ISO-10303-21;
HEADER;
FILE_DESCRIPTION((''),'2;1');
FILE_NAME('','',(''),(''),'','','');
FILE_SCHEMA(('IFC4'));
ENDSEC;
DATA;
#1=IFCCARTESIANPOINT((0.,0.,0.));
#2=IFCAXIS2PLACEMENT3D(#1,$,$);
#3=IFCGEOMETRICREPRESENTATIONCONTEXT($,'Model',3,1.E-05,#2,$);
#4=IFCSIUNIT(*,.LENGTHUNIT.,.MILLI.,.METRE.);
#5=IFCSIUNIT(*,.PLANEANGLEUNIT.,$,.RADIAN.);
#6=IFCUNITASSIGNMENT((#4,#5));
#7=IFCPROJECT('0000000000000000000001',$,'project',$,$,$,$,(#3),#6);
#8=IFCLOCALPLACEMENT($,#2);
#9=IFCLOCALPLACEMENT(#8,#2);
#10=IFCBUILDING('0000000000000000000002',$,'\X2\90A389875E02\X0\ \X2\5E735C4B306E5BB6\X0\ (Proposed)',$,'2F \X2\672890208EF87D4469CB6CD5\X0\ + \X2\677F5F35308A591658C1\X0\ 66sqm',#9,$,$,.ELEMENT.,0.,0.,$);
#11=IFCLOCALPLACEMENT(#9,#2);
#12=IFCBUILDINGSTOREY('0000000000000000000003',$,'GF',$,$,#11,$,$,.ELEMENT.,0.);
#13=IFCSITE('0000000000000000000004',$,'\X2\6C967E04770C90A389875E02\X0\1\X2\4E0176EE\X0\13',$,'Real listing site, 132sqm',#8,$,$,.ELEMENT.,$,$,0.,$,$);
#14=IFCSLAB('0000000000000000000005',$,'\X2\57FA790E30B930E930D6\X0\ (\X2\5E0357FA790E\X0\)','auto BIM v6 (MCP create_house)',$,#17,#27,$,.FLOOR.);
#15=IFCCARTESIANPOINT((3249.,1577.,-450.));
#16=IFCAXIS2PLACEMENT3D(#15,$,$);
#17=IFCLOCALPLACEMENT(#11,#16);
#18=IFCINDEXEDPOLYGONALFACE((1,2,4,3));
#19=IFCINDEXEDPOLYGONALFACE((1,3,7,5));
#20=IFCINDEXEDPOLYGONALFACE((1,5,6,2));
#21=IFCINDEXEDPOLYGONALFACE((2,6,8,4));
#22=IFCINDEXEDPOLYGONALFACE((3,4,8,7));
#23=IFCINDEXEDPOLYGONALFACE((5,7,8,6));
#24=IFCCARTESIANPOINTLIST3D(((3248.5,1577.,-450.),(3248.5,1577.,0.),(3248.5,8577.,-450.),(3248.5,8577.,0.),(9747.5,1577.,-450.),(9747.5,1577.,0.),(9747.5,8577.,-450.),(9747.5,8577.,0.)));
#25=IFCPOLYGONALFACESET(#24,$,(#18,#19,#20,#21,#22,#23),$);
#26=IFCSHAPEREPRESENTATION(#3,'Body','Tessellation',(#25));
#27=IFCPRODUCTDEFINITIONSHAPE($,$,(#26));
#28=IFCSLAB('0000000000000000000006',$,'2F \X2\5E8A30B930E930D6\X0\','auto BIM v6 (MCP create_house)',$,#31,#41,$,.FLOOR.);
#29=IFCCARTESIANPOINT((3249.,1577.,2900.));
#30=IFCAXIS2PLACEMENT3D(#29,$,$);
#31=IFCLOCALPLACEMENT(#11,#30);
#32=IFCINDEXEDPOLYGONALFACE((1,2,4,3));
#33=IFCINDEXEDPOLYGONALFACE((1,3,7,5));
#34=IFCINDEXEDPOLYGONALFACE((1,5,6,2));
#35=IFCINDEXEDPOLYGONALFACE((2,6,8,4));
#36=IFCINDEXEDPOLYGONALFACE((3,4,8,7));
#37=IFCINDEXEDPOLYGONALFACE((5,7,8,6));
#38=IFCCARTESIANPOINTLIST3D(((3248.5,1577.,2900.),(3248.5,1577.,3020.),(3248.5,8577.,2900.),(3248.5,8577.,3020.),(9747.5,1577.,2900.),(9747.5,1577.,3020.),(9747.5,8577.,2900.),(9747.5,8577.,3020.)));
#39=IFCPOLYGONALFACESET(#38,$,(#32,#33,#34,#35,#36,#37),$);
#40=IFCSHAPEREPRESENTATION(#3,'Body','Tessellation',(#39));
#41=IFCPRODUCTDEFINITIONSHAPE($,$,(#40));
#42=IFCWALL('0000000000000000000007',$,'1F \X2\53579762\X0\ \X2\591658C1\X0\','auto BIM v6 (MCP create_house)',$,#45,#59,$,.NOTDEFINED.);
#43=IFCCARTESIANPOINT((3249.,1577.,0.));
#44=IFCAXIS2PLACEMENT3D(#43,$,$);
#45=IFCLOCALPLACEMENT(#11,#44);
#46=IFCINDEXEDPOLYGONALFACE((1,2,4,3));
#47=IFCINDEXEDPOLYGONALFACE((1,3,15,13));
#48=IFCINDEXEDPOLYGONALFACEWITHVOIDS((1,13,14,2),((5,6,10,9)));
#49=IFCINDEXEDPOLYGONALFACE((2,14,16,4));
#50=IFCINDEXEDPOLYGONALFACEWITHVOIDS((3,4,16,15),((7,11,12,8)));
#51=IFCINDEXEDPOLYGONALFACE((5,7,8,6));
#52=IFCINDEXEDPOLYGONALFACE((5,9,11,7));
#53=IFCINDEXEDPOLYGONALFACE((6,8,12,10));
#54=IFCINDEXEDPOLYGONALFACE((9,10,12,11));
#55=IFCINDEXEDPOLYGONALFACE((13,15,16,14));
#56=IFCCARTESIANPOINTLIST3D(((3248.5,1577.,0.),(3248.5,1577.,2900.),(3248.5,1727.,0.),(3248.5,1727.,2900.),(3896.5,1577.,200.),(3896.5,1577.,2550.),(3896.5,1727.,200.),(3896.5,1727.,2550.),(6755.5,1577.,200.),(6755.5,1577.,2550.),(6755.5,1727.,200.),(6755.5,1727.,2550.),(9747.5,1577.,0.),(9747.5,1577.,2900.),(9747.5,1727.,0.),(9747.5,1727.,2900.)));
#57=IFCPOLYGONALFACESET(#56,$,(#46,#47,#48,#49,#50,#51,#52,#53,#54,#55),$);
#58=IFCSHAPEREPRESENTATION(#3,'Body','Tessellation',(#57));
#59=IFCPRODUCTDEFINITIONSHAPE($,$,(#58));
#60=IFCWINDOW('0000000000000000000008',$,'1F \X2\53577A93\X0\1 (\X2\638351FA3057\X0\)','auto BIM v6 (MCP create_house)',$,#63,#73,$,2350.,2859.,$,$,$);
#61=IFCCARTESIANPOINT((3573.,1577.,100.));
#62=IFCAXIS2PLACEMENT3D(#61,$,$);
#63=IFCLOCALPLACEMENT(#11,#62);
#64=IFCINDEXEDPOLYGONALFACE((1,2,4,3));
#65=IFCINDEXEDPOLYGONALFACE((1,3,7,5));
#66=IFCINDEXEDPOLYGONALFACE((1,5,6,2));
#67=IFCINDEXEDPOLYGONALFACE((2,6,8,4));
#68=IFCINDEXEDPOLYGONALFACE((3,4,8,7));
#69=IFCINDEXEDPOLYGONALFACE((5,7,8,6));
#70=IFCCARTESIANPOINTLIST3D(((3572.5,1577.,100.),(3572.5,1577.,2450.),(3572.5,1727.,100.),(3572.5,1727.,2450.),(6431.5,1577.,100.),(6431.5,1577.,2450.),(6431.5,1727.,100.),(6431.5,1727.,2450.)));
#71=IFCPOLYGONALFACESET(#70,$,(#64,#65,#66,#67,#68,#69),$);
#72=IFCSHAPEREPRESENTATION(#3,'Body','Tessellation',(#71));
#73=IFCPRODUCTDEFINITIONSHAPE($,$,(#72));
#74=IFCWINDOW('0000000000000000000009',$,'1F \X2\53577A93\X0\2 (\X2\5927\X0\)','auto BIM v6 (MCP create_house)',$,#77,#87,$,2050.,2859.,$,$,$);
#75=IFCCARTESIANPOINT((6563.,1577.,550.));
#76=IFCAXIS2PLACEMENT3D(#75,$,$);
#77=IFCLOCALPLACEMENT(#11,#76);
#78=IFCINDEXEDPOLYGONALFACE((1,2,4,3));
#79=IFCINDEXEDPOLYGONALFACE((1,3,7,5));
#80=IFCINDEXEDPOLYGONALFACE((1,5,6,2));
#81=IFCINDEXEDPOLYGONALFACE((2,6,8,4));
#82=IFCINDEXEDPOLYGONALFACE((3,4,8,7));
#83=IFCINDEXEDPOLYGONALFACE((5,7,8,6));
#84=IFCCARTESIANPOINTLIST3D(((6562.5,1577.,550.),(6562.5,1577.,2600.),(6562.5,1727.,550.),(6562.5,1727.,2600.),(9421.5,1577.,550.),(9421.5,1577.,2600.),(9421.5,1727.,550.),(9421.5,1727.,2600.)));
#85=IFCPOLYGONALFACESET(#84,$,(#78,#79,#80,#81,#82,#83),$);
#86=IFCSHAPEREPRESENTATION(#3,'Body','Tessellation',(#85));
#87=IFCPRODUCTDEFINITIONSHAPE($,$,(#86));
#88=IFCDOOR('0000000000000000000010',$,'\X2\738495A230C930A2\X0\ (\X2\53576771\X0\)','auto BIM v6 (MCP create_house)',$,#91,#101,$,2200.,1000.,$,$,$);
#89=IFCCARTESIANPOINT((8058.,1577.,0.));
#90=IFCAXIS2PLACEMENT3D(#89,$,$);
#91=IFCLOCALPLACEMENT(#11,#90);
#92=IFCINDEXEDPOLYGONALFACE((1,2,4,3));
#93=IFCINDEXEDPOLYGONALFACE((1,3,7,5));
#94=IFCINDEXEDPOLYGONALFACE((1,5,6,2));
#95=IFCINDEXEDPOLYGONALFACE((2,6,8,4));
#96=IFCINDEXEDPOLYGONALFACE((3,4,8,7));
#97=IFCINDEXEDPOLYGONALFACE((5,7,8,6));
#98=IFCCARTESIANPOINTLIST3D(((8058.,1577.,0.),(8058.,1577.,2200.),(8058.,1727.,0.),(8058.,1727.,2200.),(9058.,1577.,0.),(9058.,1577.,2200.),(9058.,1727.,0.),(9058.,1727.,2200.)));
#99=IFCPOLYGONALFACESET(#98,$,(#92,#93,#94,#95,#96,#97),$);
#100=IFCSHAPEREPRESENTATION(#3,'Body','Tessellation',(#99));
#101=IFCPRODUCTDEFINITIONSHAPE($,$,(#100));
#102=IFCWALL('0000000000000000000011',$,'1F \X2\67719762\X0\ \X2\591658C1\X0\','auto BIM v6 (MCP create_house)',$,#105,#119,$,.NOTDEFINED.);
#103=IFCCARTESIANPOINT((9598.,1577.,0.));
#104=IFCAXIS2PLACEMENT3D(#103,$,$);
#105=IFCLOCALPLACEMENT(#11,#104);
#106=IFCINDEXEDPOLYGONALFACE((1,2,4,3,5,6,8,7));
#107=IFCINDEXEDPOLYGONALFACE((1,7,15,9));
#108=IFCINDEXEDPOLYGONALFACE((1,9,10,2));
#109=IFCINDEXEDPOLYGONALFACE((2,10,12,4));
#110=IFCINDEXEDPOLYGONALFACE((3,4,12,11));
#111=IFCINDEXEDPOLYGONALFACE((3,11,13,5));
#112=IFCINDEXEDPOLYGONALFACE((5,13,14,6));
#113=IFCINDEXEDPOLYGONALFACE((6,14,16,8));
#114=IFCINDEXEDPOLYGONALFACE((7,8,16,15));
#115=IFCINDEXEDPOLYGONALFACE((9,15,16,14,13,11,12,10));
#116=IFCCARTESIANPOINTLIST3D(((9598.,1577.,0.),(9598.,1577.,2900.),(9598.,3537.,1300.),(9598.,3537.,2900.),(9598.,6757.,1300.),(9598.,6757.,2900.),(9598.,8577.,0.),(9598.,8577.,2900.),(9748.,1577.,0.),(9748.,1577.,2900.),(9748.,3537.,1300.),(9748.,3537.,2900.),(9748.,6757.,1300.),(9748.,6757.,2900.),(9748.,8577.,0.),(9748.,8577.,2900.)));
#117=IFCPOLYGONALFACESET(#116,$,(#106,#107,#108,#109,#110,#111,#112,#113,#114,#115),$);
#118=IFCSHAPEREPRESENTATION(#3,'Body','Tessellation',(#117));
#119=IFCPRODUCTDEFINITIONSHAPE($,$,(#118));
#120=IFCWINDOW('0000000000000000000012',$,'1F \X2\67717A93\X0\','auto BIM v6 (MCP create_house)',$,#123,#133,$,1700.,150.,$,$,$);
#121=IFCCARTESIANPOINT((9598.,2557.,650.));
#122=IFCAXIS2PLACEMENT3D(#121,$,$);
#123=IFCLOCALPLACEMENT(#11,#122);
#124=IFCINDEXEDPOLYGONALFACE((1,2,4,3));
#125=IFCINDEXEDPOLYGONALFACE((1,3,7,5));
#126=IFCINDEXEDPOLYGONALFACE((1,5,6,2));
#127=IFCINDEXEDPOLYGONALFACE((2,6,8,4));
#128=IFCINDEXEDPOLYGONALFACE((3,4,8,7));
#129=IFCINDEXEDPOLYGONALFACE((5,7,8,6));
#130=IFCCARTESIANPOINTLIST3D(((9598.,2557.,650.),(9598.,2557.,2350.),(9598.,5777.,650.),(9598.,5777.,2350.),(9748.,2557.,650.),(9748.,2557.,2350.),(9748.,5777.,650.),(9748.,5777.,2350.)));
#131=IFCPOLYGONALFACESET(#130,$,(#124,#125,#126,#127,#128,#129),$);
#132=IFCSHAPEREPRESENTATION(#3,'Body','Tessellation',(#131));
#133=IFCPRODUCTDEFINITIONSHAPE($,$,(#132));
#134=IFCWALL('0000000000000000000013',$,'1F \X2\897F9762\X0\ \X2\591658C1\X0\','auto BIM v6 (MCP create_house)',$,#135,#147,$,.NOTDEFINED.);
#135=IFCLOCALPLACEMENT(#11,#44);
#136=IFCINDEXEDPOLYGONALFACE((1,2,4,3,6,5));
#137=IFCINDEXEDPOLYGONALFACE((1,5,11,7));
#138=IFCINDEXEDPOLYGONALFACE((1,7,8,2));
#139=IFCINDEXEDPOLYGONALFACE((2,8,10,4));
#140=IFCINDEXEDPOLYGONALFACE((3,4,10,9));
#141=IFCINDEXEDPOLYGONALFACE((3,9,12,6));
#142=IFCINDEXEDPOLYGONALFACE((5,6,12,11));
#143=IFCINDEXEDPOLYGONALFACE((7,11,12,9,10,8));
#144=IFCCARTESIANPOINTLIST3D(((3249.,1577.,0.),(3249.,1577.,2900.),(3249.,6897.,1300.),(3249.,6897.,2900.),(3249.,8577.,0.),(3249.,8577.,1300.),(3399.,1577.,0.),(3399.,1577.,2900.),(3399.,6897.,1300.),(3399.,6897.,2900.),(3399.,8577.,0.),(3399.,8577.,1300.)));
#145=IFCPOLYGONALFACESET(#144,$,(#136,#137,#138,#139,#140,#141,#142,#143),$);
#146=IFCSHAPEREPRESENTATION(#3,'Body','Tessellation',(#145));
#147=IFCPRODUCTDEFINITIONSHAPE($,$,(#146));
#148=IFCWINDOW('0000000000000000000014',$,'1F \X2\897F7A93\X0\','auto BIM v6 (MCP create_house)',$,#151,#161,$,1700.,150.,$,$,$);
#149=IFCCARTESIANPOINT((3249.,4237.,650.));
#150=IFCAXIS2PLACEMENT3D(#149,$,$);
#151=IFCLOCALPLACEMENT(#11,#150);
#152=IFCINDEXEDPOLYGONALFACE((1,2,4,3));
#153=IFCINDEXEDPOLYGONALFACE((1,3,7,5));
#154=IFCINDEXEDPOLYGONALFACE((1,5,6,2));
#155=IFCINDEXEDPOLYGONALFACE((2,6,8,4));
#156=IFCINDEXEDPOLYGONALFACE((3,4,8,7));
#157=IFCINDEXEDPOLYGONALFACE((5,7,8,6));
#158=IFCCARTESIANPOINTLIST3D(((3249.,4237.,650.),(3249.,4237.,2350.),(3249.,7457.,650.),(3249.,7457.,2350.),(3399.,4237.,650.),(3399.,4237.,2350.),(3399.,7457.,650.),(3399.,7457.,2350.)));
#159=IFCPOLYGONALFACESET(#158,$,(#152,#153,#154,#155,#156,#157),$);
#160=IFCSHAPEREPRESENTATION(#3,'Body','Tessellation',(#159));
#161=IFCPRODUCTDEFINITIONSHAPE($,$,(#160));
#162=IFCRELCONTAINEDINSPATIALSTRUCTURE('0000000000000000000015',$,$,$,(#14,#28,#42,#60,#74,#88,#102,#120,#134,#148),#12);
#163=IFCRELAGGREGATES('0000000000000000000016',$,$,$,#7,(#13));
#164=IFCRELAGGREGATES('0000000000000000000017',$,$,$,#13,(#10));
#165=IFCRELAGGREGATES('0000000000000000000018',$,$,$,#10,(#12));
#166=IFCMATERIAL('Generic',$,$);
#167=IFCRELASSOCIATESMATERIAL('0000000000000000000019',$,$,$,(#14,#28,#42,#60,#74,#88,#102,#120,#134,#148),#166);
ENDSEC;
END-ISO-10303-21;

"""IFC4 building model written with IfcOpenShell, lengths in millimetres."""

from ifc_helpers import new_model, si_unit, frame, frame_2d, origin, place, context, project, spatial, rectangle, extrude, material, element, fill, save


model = new_model("IFC4")

# Units and contexts
model_context = context("Model", 3, precision=1e-05, world=origin())
ifc_project = project(units=[si_unit("LENGTHUNIT", "METRE", prefix="MILLI"), si_unit("PLANEANGLEUNIT", "RADIAN")], contexts=[model_context])

# Site, building, storey
site_placement = place(None, origin())
site = spatial("IfcSite", under=ifc_project, at=site_placement, Name="沖縄県那覇市1丁目13", ObjectType="Real listing site, 132sqm", CompositionType="ELEMENT", RefElevation=0.0)
building_placement = place(site_placement, origin())
building = spatial("IfcBuilding", under=site, at=building_placement, Name="那覇市 平屋の家 (Proposed)", ObjectType="2F 木造軸組構法 + 板張り外壁 66sqm", CompositionType="ELEMENT", ElevationOfRefHeight=0.0, ElevationOfTerrain=0.0)
storey_placement = place(building_placement, origin())
storey = spatial("IfcBuildingStorey", under=building, at=storey_placement, Name="GF", CompositionType="ELEMENT", Elevation=0.0)

# Slabs
ifc_material = material(Name="Generic")
slab_1_placement = place(storey_placement, frame((3249.0, 1577.0, -450.0)))
element("IfcSlab", 1, at=slab_1_placement, inside=storey, material=ifc_material, Name="基礎スラブ (布基礎)", Description="auto BIM v6 (MCP create_house)", PredefinedType="FLOOR", context=model_context, shape_type="SweptSolid", body=[
    extrude(rectangle(XDim=6499.0, YDim=7000.0, at=frame_2d((3249.0, 3500.0))), frame((3249.0, 1577.0, -450.0)), (0.0, 0.0, 1.0), 450.0),
])
slab_2_placement = place(storey_placement, frame((3249.0, 1577.0, 2900.0)))
element("IfcSlab", 2, at=slab_2_placement, inside=storey, material=ifc_material, Name="2F 床スラブ", Description="auto BIM v6 (MCP create_house)", PredefinedType="FLOOR", context=model_context, shape_type="SweptSolid", body=[
    extrude(rectangle(XDim=6499.0, YDim=7000.0, at=frame_2d((3249.0, 3500.0))), frame((3249.0, 1577.0, 2900.0)), (0.0, 0.0, 1.0), 120.0),
])

# Wall, openings, windows, door
wall_1_placement = place(storey_placement, frame((3249.0, 1577.0, 0.0)))
wall_1 = element("IfcWall", 3, at=wall_1_placement, inside=storey, material=ifc_material, Name="1F 南面 外壁", Description="auto BIM v6 (MCP create_house)", PredefinedType="NOTDEFINED", context=model_context, shape_type="SweptSolid", body=[
    extrude(rectangle(XDim=6499.0, YDim=150.0, at=frame_2d((3249.0, 75.0))), frame((3249.0, 1577.0, 0.0)), (0.0, 0.0, 1.0), 2900.0),
])
opening_1_placement = place(storey_placement, frame((3573.0, 1577.0, 100.0)))
opening_1 = element("IfcOpeningElement", 4, at=opening_1_placement, cuts=wall_1, PredefinedType="NOTDEFINED", context=model_context, shape_type="SweptSolid", body=[
    extrude(rectangle(XDim=2859.0, YDim=150.0, at=frame_2d((1429.0, 75.0))), frame((3573.0, 1577.0, 100.0)), (0.0, 0.0, 1.0), 2350.0),
])
opening_2_placement = place(storey_placement, frame((6563.0, 1577.0, 550.0)))
opening_2 = element("IfcOpeningElement", 5, at=opening_2_placement, cuts=wall_1, PredefinedType="NOTDEFINED", context=model_context, shape_type="SweptSolid", body=[
    extrude(rectangle(XDim=2859.0, YDim=150.0, at=frame_2d((1429.0, 75.0))), frame((6563.0, 1577.0, 550.0)), (0.0, 0.0, 1.0), 2050.0),
])
opening_3_placement = place(storey_placement, frame((8058.0, 1577.0, 0.0)))
opening_3 = element("IfcOpeningElement", 6, at=opening_3_placement, cuts=wall_1, PredefinedType="NOTDEFINED", context=model_context, shape_type="SweptSolid", body=[
    extrude(rectangle(XDim=1000.0, YDim=150.0, at=frame_2d((500.0, 75.0))), frame((8058.0, 1577.0, 0.0)), (0.0, 0.0, 1.0), 2200.0),
])
window_1_placement = place(storey_placement, frame((3573.0, 1577.0, 100.0)))
window_1 = element("IfcWindow", 7, at=window_1_placement, inside=storey, material=ifc_material, Name="1F 南窓1 (掃出し)", Description="auto BIM v6 (MCP create_house)", OverallHeight=2350.0, OverallWidth=2859.0, context=model_context, shape_type="SweptSolid", body=[
    extrude(rectangle(XDim=2859.0, YDim=150.0, at=frame_2d((1429.0, 75.0))), frame((3573.0, 1577.0, 100.0)), (0.0, 0.0, 1.0), 2350.0),
])
fill(opening_1, window_1)
window_2_placement = place(storey_placement, frame((6563.0, 1577.0, 550.0)))
window_2 = element("IfcWindow", 8, at=window_2_placement, inside=storey, material=ifc_material, Name="1F 南窓2 (大)", Description="auto BIM v6 (MCP create_house)", OverallHeight=2050.0, OverallWidth=2859.0, context=model_context, shape_type="SweptSolid", body=[
    extrude(rectangle(XDim=2859.0, YDim=150.0, at=frame_2d((1429.0, 75.0))), frame((6563.0, 1577.0, 550.0)), (0.0, 0.0, 1.0), 2050.0),
])
fill(opening_2, window_2)
door_placement = place(storey_placement, frame((8058.0, 1577.0, 0.0)))
door = element("IfcDoor", 9, at=door_placement, inside=storey, material=ifc_material, Name="玄関ドア (南東)", Description="auto BIM v6 (MCP create_house)", OverallHeight=2200.0, OverallWidth=1000.0, context=model_context, shape_type="SweptSolid", body=[
    extrude(rectangle(XDim=1000.0, YDim=150.0, at=frame_2d((500.0, 75.0))), frame((8058.0, 1577.0, 0.0)), (0.0, 0.0, 1.0), 2200.0),
])
fill(opening_3, door)

# Walls, openings, windows
wall_2_placement = place(storey_placement, frame((9598.0, 1577.0, 0.0)))
wall_2 = element("IfcWall", 10, at=wall_2_placement, inside=storey, material=ifc_material, Name="1F 東面 外壁", Description="auto BIM v6 (MCP create_house)", PredefinedType="NOTDEFINED", context=model_context, shape_type="SweptSolid", body=[
    extrude(rectangle(XDim=150.0, YDim=7000.0, at=frame_2d((75.0, 3500.0))), frame((9598.0, 1577.0, 0.0)), (0.0, 0.0, 1.0), 2900.0),
])
opening_4_placement = place(storey_placement, frame((9598.0, 2557.0, 650.0)))
opening_4 = element("IfcOpeningElement", 11, at=opening_4_placement, cuts=wall_2, PredefinedType="NOTDEFINED", context=model_context, shape_type="SweptSolid", body=[
    extrude(rectangle(XDim=150.0, YDim=3220.0, at=frame_2d((75.0, 1610.0))), frame((9598.0, 2557.0, 650.0)), (0.0, 0.0, 1.0), 1700.0),
])
window_3_placement = place(storey_placement, frame((9598.0, 2557.0, 650.0)))
window_3 = element("IfcWindow", 12, at=window_3_placement, inside=storey, material=ifc_material, Name="1F 東窓", Description="auto BIM v6 (MCP create_house)", OverallHeight=1700.0, OverallWidth=150.0, context=model_context, shape_type="SweptSolid", body=[
    extrude(rectangle(XDim=150.0, YDim=3220.0, at=frame_2d((75.0, 1610.0))), frame((9598.0, 2557.0, 650.0)), (0.0, 0.0, 1.0), 1700.0),
])
fill(opening_4, window_3)
wall_3_placement = place(storey_placement, frame((3249.0, 1577.0, 0.0)))
wall_3 = element("IfcWall", 13, at=wall_3_placement, inside=storey, material=ifc_material, Name="1F 西面 外壁", Description="auto BIM v6 (MCP create_house)", PredefinedType="NOTDEFINED", context=model_context, shape_type="SweptSolid", body=[
    extrude(rectangle(XDim=150.0, YDim=7000.0, at=frame_2d((75.0, 3500.0))), frame((3249.0, 1577.0, 0.0)), (0.0, 0.0, 1.0), 2900.0),
])
opening_5_placement = place(storey_placement, frame((3249.0, 4237.0, 650.0)))
opening_5 = element("IfcOpeningElement", 14, at=opening_5_placement, cuts=wall_3, PredefinedType="NOTDEFINED", context=model_context, shape_type="SweptSolid", body=[
    extrude(rectangle(XDim=150.0, YDim=3220.0, at=frame_2d((75.0, 1610.0))), frame((3249.0, 4237.0, 650.0)), (0.0, 0.0, 1.0), 1700.0),
])
window_4_placement = place(storey_placement, frame((3249.0, 4237.0, 650.0)))
window_4 = element("IfcWindow", 15, at=window_4_placement, inside=storey, material=ifc_material, Name="1F 西窓", Description="auto BIM v6 (MCP create_house)", OverallHeight=1700.0, OverallWidth=150.0, context=model_context, shape_type="SweptSolid", body=[
    extrude(rectangle(XDim=150.0, YDim=3220.0, at=frame_2d((75.0, 1610.0))), frame((3249.0, 4237.0, 650.0)), (0.0, 0.0, 1.0), 1700.0),
])
fill(opening_5, window_4)

save(model, "model.ifc")
